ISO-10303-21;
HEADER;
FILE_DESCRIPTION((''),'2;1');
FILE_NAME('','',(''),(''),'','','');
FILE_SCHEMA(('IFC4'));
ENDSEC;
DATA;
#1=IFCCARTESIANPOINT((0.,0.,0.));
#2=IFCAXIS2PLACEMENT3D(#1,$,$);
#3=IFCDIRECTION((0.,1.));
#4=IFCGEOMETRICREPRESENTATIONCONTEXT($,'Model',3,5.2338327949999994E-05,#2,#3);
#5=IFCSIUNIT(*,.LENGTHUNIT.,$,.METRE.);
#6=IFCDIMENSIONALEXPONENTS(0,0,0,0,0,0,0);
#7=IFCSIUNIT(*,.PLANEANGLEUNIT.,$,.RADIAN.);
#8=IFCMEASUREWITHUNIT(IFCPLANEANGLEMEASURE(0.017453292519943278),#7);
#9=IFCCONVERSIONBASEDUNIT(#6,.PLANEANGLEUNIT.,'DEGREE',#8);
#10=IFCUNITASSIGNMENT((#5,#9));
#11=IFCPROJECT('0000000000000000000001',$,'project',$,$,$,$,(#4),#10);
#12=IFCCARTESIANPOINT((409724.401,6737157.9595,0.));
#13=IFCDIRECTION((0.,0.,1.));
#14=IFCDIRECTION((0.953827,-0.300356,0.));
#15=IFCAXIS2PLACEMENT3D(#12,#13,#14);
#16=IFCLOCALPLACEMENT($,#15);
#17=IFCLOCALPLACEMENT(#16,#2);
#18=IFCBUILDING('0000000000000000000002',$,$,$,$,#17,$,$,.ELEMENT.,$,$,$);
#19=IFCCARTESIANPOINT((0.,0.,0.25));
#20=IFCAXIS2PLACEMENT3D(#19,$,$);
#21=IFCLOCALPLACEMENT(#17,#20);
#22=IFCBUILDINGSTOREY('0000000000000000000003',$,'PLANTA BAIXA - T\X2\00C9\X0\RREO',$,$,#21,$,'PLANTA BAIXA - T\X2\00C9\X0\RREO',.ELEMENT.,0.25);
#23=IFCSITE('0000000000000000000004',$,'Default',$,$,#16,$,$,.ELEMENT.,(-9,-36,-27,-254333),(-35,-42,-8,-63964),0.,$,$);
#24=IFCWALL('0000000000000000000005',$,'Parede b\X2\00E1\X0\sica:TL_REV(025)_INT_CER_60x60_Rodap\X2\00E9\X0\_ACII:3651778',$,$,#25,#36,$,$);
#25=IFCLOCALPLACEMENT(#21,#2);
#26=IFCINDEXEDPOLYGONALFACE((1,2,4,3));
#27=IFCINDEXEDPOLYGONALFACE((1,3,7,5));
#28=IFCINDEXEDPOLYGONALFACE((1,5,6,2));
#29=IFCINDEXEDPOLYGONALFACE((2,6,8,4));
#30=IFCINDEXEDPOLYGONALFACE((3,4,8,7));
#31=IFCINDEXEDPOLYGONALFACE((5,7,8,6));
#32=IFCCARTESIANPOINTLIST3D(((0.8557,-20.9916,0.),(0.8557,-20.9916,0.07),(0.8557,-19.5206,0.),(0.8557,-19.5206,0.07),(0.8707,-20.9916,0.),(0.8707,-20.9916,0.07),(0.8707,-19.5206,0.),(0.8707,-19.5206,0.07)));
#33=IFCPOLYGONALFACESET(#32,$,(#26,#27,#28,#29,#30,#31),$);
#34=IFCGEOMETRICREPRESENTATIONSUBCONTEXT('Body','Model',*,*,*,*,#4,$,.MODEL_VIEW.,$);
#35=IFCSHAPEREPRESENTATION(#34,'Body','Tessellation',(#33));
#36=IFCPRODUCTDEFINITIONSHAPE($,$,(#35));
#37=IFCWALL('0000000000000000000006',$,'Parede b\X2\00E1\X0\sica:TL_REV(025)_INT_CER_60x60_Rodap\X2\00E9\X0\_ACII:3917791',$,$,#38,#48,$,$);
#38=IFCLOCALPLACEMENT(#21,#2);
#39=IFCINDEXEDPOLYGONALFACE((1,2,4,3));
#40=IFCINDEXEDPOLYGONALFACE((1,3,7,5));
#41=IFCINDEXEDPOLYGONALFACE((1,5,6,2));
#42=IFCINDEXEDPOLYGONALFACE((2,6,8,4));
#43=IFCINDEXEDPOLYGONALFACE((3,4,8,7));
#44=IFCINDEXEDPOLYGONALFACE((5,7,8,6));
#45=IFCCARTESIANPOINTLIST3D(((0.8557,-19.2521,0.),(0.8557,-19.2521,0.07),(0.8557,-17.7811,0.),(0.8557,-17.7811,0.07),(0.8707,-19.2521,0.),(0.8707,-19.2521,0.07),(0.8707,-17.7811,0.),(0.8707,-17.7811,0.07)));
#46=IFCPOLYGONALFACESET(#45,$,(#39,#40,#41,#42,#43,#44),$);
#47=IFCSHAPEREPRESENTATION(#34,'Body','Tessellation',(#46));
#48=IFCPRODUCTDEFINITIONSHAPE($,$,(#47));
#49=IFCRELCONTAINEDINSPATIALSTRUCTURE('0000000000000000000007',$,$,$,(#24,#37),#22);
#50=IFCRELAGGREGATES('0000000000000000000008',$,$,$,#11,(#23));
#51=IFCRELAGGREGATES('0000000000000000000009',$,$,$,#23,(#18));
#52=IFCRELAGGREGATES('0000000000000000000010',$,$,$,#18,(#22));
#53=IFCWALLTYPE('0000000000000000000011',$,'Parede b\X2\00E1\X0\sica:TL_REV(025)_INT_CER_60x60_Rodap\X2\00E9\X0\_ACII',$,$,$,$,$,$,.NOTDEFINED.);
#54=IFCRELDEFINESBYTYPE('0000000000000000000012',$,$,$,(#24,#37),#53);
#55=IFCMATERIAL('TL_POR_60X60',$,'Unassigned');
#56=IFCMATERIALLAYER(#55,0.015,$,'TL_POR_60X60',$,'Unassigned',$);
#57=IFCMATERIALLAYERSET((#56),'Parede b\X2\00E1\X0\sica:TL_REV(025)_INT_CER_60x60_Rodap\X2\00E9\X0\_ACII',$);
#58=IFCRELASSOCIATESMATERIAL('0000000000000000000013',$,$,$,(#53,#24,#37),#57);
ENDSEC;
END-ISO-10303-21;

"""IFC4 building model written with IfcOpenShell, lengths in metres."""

from ifc_helpers import new_model, entity, si_unit, converted_unit, direction, frame, frame_2d, origin, place, context, subcontext, project, spatial, rectangle, extrude, material, layer, layer_set, layer_usage, type_object, element, save


model = new_model("IFC4")

# Units and contexts
model_context = context("Model", 3, precision=5.2338327949999994e-05, world=origin(), true_north=direction((0.0, 1.0)))
body_context = subcontext(model_context, "Body", "Model", "MODEL_VIEW")
ifc_project = project(units=[si_unit("LENGTHUNIT", "METRE"), converted_unit("PLANEANGLEUNIT", "DEGREE", entity("IfcPlaneAngleMeasure", 0.017453292519943278), si_unit("PLANEANGLEUNIT", "RADIAN"), dimensions=[0, 0, 0, 0, 0, 0, 0])], contexts=[model_context])

# Site, building, storey
site_placement = place(None, frame((409724.401, 6737157.9595, 0.0), z_axis=(0.0, 0.0, 1.0), x_axis=(0.953827, -0.300356, 0.0)))
site = spatial("IfcSite", under=ifc_project, at=site_placement, Name="Default", CompositionType="ELEMENT", RefLatitude=(-9, -36, -27, -254333), RefLongitude=(-35, -42, -8, -63964), RefElevation=0.0)
building_placement = place(site_placement, origin())
building = spatial("IfcBuilding", under=site, at=building_placement, CompositionType="ELEMENT")
storey_placement = place(building_placement, frame((0.0, 0.0, 0.25)))
storey = spatial("IfcBuildingStorey", under=building, at=storey_placement, Name="PLANTA BAIXA - TÉRREO", LongName="PLANTA BAIXA - TÉRREO", CompositionType="ELEMENT", Elevation=0.25)

# Walls
ifc_material_1 = material(Name="TL_POR_60X60", Category="Unassigned")
ifc_layer_1 = layer(ifc_material_1, 0.015, Name="TL_POR_60X60", Category="Unassigned")
ifc_layer_set_1 = layer_set([ifc_layer_1], Name="Parede básica:TL_REV(025)_INT_CER_60x60_Rodapé_ACII")
ifc_layer_usage_1 = layer_usage(ifc_layer_set_1, "AXIS2", "NEGATIVE", 0.0075)
wall_type_1 = type_object("IfcWallType", Name="Parede básica:TL_REV(025)_INT_CER_60x60_Rodapé_ACII", PredefinedType="NOTDEFINED", material=ifc_layer_set_1)
wall_1_placement = place(storey_placement, frame((0.8632, -19.5206, 0.0), z_axis=(0.0, 0.0, 1.0), x_axis=(0.0, -1.0, 0.0)))
element("IfcWall", 1, at=wall_1_placement, inside=storey, type_object=wall_type_1, material=ifc_layer_usage_1, Name="Parede básica:TL_REV(025)_INT_CER_60x60_Rodapé_ACII:3651778", context=body_context, shape_type="SweptSolid", body=[
    extrude(rectangle(XDim=1.471, YDim=0.015, at=frame_2d((0.7355, 0.0), x_axis=(-1.0, 0.0))), origin(), (0.0, 0.0, 1.0), 0.07),
])
ifc_layer_usage_2 = layer_usage(ifc_layer_set_1, "AXIS2", "POSITIVE", -0.0075)
wall_2_placement = place(storey_placement, frame((0.8632, -19.2521, 0.0), z_axis=(0.0, 0.0, 1.0), x_axis=(0.0, 1.0, 0.0)))
element("IfcWall", 2, at=wall_2_placement, inside=storey, type_object=wall_type_1, material=ifc_layer_usage_2, Name="Parede básica:TL_REV(025)_INT_CER_60x60_Rodapé_ACII:3917791", context=body_context, shape_type="SweptSolid", body=[
    extrude(rectangle(XDim=1.471, YDim=0.015, at=frame_2d((0.7355, 0.0), x_axis=(-1.0, 0.0))), origin(), (0.0, 0.0, 1.0), 0.07),
])

save(model, "model.ifc")
